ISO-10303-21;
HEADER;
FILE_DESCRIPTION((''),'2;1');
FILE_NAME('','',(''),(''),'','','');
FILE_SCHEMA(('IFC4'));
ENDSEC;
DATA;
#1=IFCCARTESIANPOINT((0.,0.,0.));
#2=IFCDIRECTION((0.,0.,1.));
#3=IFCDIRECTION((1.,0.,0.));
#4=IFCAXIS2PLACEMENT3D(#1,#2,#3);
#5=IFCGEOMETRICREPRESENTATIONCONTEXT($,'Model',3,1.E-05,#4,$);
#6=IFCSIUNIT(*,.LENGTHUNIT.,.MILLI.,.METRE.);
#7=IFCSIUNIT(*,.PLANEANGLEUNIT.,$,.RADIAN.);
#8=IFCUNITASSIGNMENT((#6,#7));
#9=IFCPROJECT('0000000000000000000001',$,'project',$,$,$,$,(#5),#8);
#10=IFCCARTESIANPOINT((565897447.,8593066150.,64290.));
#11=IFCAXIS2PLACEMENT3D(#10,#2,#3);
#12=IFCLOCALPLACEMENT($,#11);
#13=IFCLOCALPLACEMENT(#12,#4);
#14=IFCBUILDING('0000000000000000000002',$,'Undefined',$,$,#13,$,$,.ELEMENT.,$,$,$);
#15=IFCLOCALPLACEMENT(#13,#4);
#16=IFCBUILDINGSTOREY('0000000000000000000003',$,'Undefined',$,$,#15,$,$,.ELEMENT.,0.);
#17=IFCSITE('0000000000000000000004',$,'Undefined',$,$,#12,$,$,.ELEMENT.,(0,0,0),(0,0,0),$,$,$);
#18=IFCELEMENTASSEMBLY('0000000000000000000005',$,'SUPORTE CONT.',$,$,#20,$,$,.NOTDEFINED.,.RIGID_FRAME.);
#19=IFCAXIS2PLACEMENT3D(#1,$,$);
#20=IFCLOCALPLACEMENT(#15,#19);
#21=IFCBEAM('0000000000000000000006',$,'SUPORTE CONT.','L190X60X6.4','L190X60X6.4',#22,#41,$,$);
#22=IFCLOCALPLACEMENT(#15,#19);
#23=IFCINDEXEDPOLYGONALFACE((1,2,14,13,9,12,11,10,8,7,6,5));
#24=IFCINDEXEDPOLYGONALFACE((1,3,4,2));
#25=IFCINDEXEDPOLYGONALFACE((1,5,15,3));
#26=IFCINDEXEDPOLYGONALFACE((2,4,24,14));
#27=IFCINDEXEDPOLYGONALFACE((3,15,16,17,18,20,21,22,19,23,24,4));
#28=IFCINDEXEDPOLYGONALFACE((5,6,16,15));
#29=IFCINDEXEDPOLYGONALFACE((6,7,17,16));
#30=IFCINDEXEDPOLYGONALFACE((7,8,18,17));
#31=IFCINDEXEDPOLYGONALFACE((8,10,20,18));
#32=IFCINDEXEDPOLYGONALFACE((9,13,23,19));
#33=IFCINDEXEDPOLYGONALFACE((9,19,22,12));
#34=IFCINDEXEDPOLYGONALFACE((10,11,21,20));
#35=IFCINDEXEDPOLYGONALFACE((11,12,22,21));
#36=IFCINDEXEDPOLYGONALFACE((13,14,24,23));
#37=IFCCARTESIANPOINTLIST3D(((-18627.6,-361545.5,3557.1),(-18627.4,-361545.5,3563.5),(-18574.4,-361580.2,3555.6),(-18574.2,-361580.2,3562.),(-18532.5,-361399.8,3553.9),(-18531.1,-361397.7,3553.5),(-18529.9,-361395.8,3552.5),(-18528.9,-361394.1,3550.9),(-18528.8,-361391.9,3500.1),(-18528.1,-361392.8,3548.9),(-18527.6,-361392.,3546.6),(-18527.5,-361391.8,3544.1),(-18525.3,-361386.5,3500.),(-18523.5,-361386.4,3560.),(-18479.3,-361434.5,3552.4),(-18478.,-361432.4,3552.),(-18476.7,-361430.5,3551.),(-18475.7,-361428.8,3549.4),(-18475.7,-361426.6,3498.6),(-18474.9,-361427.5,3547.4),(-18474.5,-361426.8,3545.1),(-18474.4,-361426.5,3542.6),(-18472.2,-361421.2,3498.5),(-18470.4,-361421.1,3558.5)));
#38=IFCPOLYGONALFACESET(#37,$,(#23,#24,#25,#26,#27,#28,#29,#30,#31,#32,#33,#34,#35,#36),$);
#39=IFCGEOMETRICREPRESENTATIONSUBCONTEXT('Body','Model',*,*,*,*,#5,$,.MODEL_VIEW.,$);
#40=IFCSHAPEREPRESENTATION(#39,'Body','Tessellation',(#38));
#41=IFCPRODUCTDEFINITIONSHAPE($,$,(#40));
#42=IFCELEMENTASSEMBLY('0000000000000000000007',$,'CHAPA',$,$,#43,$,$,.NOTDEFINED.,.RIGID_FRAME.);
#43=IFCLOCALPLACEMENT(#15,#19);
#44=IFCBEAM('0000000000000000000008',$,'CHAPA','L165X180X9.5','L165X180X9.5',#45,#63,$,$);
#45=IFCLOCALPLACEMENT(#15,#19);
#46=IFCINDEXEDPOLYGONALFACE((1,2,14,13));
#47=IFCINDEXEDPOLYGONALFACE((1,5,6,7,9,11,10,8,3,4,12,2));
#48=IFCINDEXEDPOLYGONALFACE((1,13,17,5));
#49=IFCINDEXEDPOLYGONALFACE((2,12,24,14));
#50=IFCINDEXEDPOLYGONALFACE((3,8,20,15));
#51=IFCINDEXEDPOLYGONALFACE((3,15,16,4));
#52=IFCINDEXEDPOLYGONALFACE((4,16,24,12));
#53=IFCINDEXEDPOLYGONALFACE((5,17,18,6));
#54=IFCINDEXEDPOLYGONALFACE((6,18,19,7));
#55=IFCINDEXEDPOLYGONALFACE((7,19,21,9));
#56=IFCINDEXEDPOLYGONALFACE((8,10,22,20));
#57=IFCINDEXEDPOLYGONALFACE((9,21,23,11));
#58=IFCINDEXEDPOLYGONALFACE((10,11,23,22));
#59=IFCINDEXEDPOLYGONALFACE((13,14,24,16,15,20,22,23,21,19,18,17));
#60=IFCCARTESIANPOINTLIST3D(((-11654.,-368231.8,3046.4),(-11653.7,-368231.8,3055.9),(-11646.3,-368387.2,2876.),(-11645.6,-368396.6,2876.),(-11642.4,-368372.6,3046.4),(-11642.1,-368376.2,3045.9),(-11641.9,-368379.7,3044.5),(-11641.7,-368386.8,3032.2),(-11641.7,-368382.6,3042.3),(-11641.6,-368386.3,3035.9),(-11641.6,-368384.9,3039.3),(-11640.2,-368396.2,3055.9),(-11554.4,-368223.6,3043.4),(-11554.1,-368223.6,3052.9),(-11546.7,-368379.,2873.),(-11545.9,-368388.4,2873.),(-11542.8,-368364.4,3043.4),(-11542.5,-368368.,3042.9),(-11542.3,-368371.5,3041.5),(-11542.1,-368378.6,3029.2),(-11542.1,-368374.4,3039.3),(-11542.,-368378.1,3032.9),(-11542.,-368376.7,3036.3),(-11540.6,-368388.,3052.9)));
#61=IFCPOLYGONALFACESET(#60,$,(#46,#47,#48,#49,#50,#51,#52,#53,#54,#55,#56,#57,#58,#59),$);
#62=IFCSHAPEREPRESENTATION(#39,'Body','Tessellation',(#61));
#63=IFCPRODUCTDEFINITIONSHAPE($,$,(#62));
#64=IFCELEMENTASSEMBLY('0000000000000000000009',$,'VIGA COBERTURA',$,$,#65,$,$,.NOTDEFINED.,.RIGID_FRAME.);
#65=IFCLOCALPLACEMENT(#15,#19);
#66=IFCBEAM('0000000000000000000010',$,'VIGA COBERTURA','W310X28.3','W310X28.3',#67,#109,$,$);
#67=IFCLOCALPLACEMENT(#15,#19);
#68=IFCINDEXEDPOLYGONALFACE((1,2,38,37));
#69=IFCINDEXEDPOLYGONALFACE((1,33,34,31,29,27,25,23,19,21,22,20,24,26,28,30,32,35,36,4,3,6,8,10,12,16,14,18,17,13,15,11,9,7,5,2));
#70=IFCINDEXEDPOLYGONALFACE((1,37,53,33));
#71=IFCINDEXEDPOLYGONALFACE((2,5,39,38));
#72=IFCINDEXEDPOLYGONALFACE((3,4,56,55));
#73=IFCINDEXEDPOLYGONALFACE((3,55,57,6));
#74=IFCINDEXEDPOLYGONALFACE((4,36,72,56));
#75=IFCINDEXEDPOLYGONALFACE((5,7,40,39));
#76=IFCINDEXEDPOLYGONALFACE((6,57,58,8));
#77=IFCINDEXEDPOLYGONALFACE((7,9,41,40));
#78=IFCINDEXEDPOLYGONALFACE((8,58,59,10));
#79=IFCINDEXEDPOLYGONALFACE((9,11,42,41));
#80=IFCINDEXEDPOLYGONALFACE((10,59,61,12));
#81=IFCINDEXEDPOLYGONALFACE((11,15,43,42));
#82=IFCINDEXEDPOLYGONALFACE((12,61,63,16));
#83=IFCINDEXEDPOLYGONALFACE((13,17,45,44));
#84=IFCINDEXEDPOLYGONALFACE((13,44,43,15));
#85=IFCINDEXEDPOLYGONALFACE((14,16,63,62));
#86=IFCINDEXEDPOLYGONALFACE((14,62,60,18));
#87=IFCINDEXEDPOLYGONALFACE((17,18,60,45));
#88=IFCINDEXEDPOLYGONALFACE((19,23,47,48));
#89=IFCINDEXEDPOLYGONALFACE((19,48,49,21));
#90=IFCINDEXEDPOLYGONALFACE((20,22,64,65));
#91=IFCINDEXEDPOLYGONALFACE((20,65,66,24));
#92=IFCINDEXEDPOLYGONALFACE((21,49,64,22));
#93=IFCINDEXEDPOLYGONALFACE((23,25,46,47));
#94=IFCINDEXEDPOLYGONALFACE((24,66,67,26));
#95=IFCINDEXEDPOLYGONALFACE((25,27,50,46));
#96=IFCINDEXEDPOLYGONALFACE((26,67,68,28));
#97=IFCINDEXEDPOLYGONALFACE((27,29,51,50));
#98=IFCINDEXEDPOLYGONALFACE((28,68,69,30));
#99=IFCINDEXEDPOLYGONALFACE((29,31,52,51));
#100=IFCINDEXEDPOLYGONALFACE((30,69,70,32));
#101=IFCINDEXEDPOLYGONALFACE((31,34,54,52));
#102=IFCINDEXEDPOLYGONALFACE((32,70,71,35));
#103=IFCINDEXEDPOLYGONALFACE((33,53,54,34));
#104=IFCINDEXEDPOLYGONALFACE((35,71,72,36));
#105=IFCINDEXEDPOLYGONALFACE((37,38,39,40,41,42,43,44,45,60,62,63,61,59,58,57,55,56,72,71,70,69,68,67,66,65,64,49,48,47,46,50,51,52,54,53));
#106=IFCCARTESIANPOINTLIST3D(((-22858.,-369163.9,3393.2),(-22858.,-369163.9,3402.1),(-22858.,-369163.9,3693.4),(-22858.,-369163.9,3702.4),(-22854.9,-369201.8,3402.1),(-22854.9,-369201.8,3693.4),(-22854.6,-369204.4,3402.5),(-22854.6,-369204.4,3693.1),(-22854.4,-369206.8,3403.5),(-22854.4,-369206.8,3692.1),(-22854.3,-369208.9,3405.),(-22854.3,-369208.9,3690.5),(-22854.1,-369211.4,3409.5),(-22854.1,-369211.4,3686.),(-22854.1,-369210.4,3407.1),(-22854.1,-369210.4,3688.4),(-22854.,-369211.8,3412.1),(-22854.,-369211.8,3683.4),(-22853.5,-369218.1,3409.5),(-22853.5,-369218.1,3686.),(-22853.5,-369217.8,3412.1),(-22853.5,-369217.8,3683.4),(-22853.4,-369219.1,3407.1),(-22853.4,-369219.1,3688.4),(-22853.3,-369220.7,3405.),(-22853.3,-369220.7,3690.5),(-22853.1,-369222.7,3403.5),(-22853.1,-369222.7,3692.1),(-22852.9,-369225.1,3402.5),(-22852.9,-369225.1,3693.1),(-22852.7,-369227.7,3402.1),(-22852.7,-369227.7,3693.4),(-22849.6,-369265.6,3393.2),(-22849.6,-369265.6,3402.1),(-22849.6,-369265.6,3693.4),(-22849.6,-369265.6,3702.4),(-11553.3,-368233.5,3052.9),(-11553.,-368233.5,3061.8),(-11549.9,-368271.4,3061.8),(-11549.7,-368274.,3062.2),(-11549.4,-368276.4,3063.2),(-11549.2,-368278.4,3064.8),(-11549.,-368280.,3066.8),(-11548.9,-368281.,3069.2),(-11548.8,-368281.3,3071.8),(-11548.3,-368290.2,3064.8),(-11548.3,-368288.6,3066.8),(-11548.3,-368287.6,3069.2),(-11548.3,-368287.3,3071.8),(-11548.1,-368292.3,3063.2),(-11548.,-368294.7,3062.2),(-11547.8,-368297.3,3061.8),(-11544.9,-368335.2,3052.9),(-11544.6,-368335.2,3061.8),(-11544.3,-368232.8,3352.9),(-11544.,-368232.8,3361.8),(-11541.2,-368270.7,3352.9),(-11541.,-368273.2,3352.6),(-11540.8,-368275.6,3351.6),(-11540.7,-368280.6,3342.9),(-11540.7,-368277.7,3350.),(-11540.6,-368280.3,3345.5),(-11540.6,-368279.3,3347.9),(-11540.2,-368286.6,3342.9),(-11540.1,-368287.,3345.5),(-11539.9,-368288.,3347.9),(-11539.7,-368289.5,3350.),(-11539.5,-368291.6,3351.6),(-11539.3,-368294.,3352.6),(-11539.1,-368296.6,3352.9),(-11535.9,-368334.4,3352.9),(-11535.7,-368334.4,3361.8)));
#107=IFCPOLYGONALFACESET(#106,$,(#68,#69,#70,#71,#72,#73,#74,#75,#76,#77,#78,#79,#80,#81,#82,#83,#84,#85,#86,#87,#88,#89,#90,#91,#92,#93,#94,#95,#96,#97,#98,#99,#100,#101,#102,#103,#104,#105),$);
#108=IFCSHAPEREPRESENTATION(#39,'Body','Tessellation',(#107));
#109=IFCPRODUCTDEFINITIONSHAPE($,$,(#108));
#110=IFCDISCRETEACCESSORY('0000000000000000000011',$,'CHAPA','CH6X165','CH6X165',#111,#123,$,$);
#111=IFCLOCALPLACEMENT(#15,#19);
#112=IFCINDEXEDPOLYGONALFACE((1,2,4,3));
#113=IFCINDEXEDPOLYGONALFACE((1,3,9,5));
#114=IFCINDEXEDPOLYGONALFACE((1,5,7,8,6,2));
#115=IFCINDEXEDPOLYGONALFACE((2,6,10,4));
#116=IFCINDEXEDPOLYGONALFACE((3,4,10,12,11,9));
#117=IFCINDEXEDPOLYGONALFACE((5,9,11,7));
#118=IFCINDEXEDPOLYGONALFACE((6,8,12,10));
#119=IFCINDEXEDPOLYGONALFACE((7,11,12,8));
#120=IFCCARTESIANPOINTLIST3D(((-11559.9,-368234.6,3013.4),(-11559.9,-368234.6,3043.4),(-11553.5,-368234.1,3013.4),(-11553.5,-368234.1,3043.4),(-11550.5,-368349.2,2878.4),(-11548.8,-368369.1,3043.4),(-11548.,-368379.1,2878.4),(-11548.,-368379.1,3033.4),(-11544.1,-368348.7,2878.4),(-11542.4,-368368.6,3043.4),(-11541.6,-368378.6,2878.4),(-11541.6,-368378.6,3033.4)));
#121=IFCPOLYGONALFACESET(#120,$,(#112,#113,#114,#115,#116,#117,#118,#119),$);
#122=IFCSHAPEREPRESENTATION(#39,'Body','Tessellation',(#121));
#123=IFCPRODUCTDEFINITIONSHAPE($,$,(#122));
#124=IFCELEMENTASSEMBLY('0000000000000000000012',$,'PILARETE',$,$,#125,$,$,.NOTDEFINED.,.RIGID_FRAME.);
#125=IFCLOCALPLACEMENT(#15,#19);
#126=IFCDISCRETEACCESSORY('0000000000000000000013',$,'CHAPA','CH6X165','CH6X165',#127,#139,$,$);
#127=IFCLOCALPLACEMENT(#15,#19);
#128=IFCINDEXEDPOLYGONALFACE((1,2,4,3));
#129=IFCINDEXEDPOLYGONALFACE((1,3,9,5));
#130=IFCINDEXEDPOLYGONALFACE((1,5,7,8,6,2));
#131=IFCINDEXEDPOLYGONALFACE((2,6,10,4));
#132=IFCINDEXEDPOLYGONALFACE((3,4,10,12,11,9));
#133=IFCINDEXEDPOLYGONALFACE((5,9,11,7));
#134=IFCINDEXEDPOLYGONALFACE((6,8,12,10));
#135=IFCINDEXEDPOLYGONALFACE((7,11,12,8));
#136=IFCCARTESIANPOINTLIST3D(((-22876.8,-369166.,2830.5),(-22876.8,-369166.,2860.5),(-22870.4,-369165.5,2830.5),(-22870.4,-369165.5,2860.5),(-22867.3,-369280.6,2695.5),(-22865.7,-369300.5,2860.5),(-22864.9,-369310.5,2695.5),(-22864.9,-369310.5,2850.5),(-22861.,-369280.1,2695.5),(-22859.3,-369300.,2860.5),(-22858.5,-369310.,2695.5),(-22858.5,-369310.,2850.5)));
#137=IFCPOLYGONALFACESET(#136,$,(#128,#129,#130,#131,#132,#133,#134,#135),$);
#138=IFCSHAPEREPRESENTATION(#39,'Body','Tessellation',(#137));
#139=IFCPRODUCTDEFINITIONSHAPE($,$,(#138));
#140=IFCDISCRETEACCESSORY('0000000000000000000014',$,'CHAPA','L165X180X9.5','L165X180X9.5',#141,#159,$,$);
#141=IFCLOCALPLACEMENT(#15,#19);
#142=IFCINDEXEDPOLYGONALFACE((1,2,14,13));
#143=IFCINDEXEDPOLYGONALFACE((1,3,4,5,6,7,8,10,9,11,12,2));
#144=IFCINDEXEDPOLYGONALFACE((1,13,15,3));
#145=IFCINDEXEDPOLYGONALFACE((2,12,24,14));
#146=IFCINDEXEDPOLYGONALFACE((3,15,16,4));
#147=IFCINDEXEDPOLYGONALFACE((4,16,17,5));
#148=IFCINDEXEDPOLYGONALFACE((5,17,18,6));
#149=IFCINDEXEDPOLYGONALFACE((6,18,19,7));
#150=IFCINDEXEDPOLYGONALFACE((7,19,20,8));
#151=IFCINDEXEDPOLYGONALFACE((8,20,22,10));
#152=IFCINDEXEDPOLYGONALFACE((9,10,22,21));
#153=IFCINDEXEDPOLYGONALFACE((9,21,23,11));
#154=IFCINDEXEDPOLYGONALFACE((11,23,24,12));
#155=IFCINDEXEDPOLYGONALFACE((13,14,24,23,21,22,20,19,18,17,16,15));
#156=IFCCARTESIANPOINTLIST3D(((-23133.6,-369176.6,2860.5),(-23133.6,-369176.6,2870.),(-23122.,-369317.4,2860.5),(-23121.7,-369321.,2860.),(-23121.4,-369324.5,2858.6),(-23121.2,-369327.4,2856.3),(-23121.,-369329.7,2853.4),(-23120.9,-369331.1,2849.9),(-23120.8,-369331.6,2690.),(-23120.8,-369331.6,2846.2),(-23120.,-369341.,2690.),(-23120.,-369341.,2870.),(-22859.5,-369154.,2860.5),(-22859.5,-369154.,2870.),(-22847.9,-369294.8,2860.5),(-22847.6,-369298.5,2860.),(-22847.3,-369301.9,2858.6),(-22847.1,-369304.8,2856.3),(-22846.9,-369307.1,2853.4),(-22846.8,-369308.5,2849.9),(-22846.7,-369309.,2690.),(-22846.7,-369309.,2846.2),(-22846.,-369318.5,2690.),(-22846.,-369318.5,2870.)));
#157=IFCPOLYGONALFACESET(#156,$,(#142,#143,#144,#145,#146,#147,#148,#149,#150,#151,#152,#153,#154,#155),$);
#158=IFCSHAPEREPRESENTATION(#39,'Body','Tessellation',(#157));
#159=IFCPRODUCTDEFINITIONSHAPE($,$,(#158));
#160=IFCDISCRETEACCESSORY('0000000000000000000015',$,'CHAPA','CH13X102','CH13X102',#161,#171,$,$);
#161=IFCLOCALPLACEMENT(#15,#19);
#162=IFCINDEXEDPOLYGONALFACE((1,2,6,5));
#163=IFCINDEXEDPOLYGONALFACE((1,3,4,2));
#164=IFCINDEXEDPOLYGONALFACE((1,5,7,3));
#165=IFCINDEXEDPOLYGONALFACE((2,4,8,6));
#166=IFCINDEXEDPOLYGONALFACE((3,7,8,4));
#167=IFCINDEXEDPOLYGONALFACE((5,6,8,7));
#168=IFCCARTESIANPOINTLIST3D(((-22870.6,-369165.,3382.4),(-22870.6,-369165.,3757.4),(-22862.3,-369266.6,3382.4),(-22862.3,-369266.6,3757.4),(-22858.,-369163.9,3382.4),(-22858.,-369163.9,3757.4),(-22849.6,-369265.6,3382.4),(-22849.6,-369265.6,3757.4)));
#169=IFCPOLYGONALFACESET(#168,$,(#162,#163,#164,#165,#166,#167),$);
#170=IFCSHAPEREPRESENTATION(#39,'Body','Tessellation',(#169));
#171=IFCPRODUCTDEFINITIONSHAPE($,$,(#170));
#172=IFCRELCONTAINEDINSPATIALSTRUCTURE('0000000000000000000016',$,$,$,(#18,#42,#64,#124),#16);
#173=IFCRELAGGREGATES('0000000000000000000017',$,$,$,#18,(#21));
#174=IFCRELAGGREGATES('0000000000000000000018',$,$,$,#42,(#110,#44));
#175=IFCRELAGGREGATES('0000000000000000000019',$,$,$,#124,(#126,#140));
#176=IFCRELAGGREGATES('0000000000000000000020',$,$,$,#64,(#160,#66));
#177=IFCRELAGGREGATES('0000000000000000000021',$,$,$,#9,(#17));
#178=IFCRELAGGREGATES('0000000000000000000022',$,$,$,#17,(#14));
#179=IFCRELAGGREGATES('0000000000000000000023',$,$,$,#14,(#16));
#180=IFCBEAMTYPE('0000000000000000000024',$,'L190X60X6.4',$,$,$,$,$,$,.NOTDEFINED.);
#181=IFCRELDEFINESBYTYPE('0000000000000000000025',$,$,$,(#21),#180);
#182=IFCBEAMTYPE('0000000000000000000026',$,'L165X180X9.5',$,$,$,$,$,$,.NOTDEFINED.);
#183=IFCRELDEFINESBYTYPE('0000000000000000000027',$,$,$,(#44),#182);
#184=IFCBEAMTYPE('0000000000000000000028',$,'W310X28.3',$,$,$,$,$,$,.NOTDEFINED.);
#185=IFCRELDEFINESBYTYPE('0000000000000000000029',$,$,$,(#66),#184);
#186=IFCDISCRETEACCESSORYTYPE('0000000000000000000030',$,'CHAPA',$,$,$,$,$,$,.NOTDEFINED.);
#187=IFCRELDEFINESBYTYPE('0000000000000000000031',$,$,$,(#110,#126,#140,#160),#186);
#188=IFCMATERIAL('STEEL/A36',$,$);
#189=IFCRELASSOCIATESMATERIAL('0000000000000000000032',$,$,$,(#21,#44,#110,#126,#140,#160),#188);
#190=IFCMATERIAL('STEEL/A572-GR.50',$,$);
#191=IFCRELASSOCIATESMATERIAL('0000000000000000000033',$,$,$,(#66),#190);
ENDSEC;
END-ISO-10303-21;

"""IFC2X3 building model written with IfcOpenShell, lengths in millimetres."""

from ifc_helpers import new_model, si_unit, frame, origin_with_axes, origin_2d_with_axis, place, context, subcontext, project, spatial, polyline, i_section, l_section, outline, extrude, clip, halfspace, material, type_object, element, aggregate, save


model = new_model("IFC2X3")

# Units and contexts
model_context = context("Model", 3, precision=1e-05, world=origin_with_axes())
body_context = subcontext(model_context, "Body", "Model", "MODEL_VIEW")
ifc_project = project(units=[si_unit("LENGTHUNIT", "METRE", prefix="MILLI"), si_unit("PLANEANGLEUNIT", "RADIAN")], contexts=[model_context])

# Site, building, storey
site_placement = place(None, frame((565897447.0, 8593066150.0, 64290.0), z_axis=(0.0, 0.0, 1.0), x_axis=(1.0, 0.0, 0.0)))
site = spatial("IfcSite", under=ifc_project, at=site_placement, Name="Undefined", CompositionType="ELEMENT", RefLatitude=(0, 0, 0), RefLongitude=(0, 0, 0))
building_placement = place(site_placement, origin_with_axes())
building = spatial("IfcBuilding", under=site, at=building_placement, Name="Undefined", CompositionType="ELEMENT")
storey_placement = place(building_placement, origin_with_axes())
storey = spatial("IfcBuildingStorey", under=building, at=storey_placement, Name="Undefined", CompositionType="ELEMENT", Elevation=0.0)

# Element assemblies, beams
ifc_material_1 = material(Name="STEEL/A36")
beam_type_1 = type_object("IfcBeamType", Name="L190X60X6.4", PredefinedType="NOTDEFINED")
assembly_1_placement = place(storey_placement, origin_with_axes())
assembly_1 = element("IfcElementAssembly", 1, at=assembly_1_placement, inside=storey, Name="SUPORTE CONT.", AssemblyPlace="NOTDEFINED", PredefinedType="RIGID_FRAME")
beam_1_placement = place(assembly_1_placement, frame((-18576.3, -361466.0, 3531.7), z_axis=(-0.546411, -0.837315, 0.018398), x_axis=(0.836984, -0.546715, -0.02368)))
beam_1 = element("IfcBeam", 2, at=beam_1_placement, type_object=beam_type_1, material=ifc_material_1, Name="SUPORTE CONT.", Description="L190X60X6.4", ObjectType="L190X60X6.4", context=body_context, shape_type="SweptSolid", body=[
    extrude(l_section(Depth=190.0, Width=60.0, Thickness=6.4, FilletRadius=9.6, at=origin_2d_with_axis()), frame((63.5, 0.0, 0.0), z_axis=(-1.0, 0.0, 0.0), x_axis=(0.0, -1.0, 0.0)), (0.0, 0.0, 1.0), 63.5),
])
assembly_2_placement = place(storey_placement, origin_with_axes())
assembly_2 = element("IfcElementAssembly", 3, at=assembly_2_placement, inside=storey, Name="CHAPA", AssemblyPlace="NOTDEFINED", PredefinedType="RIGID_FRAME")
beam_type_2 = type_object("IfcBeamType", Name="L165X180X9.5", PredefinedType="NOTDEFINED")
beam_2_placement = place(assembly_2_placement, frame((-11550.0, -368306.0, 2963.0), z_axis=(-0.082025, 0.99663, 0.0), x_axis=(-0.996182, -0.081989, 0.029987)))
beam_2 = element("IfcBeam", 4, at=beam_2_placement, type_object=beam_type_2, material=ifc_material_1, Name="CHAPA", Description="L165X180X9.5", ObjectType="L165X180X9.5", context=body_context, shape_type="SweptSolid", body=[
    extrude(l_section(Depth=165.0, Width=180.0, Thickness=9.5, FilletRadius=14.2, at=origin_2d_with_axis()), frame((100.0, 0.0, 0.0), z_axis=(-1.0, 0.0, 0.0), x_axis=(0.0, -1.0, 0.0)), (0.0, 0.0, 1.0), 100.0),
])
assembly_3_placement = place(storey_placement, origin_with_axes())
assembly_3 = element("IfcElementAssembly", 5, at=assembly_3_placement, inside=storey, Name="VIGA COBERTURA", AssemblyPlace="NOTDEFINED", PredefinedType="RIGID_FRAME")
ifc_material_2 = material(Name="STEEL/A572-GR.50")
beam_type_3 = type_object("IfcBeamType", Name="W310X28.3", PredefinedType="NOTDEFINED")
beam_3_placement = place(assembly_3_placement, frame((-22871.1, -369216.2, 3548.3), z_axis=(-0.029885, -0.00246, -0.99955), x_axis=(0.996182, 0.081989, -0.029987)))
beam_3 = element("IfcBeam", 6, at=beam_3_placement, type_object=beam_type_3, material=ifc_material_2, Name="VIGA COBERTURA", Description="W310X28.3", ObjectType="W310X28.3", context=body_context, shape_type="Clipping", body=[
    clip(extrude(i_section(OverallWidth=102.0, OverallDepth=309.0, WebThickness=6.0, FlangeThickness=8.9, FilletRadius=10.0, at=origin_2d_with_axis()), frame((11370.0, 0.0, 0.0), z_axis=(-1.0, 0.0, 0.0), x_axis=(0.0, -1.0, 0.0)), (0.0, 0.0, 1.0), 11370.0), halfspace(frame((12.7, 51.0, -154.5), z_axis=(-0.99955, 0.0, 0.029987), x_axis=(0.029987, 0.0, 0.99955)), False)),
])

# Discrete accessory
discrete_accessory_type_1 = type_object("IfcDiscreteAccessoryType", Name="CHAPA")
aggregate(assembly_1, [beam_1])
discrete_accessory_1_placement = place(assembly_2_placement, frame((-11544.8, -368378.8, 3043.4), z_axis=(0.99663, 0.082025, 0.000004), x_axis=(0.000004, 0.0, -1.0)))
discrete_accessory_1 = element("IfcDiscreteAccessory", 7, at=discrete_accessory_1_placement, type_object=discrete_accessory_type_1, material=ifc_material_1, Name="CHAPA", Description="CH6X165", ObjectType="CH6X165", context=body_context, shape_type="SweptSolid", body=[
    extrude(outline(polyline([(0.0, 10.0), (10.0, 0.0), (165.0, 0.0), (165.0, 30.0), (30.0, 145.0), (0.0, 145.0), (0.0, 10.0)])), frame((0.0, 0.0, -3.2), z_axis=(0.0, 0.0, 1.0), x_axis=(1.0, 0.0, 0.0)), (0.0, 0.0, 1.0), 6.4),
])
aggregate(assembly_2, [discrete_accessory_1, beam_2])

# Element assembly, discrete accessories
assembly_4_placement = place(storey_placement, origin_with_axes())
assembly_4 = element("IfcElementAssembly", 8, at=assembly_4_placement, inside=storey, Name="PILARETE", AssemblyPlace="NOTDEFINED", PredefinedType="RIGID_FRAME")
discrete_accessory_2_placement = place(assembly_4_placement, frame((-22861.7, -369310.2, 2860.5), z_axis=(0.99663, 0.082025, 0.000004), x_axis=(0.000004, 0.0, -1.0)))
discrete_accessory_2 = element("IfcDiscreteAccessory", 9, at=discrete_accessory_2_placement, type_object=discrete_accessory_type_1, material=ifc_material_1, Name="CHAPA", Description="CH6X165", ObjectType="CH6X165", context=body_context, shape_type="SweptSolid", body=[
    extrude(outline(polyline([(0.0, 10.0), (10.0, 0.0), (165.0, 0.0), (165.0, 30.0), (30.0, 145.0), (0.0, 145.0), (0.0, 10.0)])), frame((0.0, 0.0, -3.2), z_axis=(0.0, 0.0, 1.0), x_axis=(1.0, 0.0, 0.0)), (0.0, 0.0, 1.0), 6.4),
])
discrete_accessory_3_placement = place(assembly_4_placement, frame((-22852.7, -369236.2, 2780.0), z_axis=(-0.082025, 0.99663, 0.0), x_axis=(-0.99663, -0.082025, 0.0)))
discrete_accessory_3 = element("IfcDiscreteAccessory", 10, at=discrete_accessory_3_placement, type_object=discrete_accessory_type_1, material=ifc_material_1, Name="CHAPA", Description="L165X180X9.5", ObjectType="L165X180X9.5", context=body_context, shape_type="SweptSolid", body=[
    extrude(l_section(Depth=165.0, Width=180.0, Thickness=9.5, FilletRadius=14.2, at=origin_2d_with_axis()), frame((275.0, 0.0, 0.0), z_axis=(-1.0, 0.0, 0.0), x_axis=(0.0, -1.0, 0.0)), (0.0, 0.0, 1.0), 275.0),
])
aggregate(assembly_4, [discrete_accessory_2, discrete_accessory_3])

# Discrete accessory
discrete_accessory_4_placement = place(assembly_3_placement, frame((-22860.1, -369215.3, 3757.4), z_axis=(-0.99663, -0.082025, 0.0), x_axis=(0.0, 0.0, -1.0)))
discrete_accessory_4 = element("IfcDiscreteAccessory", 11, at=discrete_accessory_4_placement, type_object=discrete_accessory_type_1, material=ifc_material_1, Name="CHAPA", Description="CH13X102", ObjectType="CH13X102", context=body_context, shape_type="SweptSolid", body=[
    extrude(outline(polyline([(375.0, -51.0), (0.0, -51.0), (0.0, 51.0), (375.0, 51.0), (375.0, -51.0)])), frame((0.0, 0.0, -6.3), z_axis=(0.0, 0.0, 1.0), x_axis=(1.0, 0.0, 0.0)), (0.0, 0.0, 1.0), 12.7),
])
aggregate(assembly_3, [discrete_accessory_4, beam_3])

save(model, "model.ifc")
